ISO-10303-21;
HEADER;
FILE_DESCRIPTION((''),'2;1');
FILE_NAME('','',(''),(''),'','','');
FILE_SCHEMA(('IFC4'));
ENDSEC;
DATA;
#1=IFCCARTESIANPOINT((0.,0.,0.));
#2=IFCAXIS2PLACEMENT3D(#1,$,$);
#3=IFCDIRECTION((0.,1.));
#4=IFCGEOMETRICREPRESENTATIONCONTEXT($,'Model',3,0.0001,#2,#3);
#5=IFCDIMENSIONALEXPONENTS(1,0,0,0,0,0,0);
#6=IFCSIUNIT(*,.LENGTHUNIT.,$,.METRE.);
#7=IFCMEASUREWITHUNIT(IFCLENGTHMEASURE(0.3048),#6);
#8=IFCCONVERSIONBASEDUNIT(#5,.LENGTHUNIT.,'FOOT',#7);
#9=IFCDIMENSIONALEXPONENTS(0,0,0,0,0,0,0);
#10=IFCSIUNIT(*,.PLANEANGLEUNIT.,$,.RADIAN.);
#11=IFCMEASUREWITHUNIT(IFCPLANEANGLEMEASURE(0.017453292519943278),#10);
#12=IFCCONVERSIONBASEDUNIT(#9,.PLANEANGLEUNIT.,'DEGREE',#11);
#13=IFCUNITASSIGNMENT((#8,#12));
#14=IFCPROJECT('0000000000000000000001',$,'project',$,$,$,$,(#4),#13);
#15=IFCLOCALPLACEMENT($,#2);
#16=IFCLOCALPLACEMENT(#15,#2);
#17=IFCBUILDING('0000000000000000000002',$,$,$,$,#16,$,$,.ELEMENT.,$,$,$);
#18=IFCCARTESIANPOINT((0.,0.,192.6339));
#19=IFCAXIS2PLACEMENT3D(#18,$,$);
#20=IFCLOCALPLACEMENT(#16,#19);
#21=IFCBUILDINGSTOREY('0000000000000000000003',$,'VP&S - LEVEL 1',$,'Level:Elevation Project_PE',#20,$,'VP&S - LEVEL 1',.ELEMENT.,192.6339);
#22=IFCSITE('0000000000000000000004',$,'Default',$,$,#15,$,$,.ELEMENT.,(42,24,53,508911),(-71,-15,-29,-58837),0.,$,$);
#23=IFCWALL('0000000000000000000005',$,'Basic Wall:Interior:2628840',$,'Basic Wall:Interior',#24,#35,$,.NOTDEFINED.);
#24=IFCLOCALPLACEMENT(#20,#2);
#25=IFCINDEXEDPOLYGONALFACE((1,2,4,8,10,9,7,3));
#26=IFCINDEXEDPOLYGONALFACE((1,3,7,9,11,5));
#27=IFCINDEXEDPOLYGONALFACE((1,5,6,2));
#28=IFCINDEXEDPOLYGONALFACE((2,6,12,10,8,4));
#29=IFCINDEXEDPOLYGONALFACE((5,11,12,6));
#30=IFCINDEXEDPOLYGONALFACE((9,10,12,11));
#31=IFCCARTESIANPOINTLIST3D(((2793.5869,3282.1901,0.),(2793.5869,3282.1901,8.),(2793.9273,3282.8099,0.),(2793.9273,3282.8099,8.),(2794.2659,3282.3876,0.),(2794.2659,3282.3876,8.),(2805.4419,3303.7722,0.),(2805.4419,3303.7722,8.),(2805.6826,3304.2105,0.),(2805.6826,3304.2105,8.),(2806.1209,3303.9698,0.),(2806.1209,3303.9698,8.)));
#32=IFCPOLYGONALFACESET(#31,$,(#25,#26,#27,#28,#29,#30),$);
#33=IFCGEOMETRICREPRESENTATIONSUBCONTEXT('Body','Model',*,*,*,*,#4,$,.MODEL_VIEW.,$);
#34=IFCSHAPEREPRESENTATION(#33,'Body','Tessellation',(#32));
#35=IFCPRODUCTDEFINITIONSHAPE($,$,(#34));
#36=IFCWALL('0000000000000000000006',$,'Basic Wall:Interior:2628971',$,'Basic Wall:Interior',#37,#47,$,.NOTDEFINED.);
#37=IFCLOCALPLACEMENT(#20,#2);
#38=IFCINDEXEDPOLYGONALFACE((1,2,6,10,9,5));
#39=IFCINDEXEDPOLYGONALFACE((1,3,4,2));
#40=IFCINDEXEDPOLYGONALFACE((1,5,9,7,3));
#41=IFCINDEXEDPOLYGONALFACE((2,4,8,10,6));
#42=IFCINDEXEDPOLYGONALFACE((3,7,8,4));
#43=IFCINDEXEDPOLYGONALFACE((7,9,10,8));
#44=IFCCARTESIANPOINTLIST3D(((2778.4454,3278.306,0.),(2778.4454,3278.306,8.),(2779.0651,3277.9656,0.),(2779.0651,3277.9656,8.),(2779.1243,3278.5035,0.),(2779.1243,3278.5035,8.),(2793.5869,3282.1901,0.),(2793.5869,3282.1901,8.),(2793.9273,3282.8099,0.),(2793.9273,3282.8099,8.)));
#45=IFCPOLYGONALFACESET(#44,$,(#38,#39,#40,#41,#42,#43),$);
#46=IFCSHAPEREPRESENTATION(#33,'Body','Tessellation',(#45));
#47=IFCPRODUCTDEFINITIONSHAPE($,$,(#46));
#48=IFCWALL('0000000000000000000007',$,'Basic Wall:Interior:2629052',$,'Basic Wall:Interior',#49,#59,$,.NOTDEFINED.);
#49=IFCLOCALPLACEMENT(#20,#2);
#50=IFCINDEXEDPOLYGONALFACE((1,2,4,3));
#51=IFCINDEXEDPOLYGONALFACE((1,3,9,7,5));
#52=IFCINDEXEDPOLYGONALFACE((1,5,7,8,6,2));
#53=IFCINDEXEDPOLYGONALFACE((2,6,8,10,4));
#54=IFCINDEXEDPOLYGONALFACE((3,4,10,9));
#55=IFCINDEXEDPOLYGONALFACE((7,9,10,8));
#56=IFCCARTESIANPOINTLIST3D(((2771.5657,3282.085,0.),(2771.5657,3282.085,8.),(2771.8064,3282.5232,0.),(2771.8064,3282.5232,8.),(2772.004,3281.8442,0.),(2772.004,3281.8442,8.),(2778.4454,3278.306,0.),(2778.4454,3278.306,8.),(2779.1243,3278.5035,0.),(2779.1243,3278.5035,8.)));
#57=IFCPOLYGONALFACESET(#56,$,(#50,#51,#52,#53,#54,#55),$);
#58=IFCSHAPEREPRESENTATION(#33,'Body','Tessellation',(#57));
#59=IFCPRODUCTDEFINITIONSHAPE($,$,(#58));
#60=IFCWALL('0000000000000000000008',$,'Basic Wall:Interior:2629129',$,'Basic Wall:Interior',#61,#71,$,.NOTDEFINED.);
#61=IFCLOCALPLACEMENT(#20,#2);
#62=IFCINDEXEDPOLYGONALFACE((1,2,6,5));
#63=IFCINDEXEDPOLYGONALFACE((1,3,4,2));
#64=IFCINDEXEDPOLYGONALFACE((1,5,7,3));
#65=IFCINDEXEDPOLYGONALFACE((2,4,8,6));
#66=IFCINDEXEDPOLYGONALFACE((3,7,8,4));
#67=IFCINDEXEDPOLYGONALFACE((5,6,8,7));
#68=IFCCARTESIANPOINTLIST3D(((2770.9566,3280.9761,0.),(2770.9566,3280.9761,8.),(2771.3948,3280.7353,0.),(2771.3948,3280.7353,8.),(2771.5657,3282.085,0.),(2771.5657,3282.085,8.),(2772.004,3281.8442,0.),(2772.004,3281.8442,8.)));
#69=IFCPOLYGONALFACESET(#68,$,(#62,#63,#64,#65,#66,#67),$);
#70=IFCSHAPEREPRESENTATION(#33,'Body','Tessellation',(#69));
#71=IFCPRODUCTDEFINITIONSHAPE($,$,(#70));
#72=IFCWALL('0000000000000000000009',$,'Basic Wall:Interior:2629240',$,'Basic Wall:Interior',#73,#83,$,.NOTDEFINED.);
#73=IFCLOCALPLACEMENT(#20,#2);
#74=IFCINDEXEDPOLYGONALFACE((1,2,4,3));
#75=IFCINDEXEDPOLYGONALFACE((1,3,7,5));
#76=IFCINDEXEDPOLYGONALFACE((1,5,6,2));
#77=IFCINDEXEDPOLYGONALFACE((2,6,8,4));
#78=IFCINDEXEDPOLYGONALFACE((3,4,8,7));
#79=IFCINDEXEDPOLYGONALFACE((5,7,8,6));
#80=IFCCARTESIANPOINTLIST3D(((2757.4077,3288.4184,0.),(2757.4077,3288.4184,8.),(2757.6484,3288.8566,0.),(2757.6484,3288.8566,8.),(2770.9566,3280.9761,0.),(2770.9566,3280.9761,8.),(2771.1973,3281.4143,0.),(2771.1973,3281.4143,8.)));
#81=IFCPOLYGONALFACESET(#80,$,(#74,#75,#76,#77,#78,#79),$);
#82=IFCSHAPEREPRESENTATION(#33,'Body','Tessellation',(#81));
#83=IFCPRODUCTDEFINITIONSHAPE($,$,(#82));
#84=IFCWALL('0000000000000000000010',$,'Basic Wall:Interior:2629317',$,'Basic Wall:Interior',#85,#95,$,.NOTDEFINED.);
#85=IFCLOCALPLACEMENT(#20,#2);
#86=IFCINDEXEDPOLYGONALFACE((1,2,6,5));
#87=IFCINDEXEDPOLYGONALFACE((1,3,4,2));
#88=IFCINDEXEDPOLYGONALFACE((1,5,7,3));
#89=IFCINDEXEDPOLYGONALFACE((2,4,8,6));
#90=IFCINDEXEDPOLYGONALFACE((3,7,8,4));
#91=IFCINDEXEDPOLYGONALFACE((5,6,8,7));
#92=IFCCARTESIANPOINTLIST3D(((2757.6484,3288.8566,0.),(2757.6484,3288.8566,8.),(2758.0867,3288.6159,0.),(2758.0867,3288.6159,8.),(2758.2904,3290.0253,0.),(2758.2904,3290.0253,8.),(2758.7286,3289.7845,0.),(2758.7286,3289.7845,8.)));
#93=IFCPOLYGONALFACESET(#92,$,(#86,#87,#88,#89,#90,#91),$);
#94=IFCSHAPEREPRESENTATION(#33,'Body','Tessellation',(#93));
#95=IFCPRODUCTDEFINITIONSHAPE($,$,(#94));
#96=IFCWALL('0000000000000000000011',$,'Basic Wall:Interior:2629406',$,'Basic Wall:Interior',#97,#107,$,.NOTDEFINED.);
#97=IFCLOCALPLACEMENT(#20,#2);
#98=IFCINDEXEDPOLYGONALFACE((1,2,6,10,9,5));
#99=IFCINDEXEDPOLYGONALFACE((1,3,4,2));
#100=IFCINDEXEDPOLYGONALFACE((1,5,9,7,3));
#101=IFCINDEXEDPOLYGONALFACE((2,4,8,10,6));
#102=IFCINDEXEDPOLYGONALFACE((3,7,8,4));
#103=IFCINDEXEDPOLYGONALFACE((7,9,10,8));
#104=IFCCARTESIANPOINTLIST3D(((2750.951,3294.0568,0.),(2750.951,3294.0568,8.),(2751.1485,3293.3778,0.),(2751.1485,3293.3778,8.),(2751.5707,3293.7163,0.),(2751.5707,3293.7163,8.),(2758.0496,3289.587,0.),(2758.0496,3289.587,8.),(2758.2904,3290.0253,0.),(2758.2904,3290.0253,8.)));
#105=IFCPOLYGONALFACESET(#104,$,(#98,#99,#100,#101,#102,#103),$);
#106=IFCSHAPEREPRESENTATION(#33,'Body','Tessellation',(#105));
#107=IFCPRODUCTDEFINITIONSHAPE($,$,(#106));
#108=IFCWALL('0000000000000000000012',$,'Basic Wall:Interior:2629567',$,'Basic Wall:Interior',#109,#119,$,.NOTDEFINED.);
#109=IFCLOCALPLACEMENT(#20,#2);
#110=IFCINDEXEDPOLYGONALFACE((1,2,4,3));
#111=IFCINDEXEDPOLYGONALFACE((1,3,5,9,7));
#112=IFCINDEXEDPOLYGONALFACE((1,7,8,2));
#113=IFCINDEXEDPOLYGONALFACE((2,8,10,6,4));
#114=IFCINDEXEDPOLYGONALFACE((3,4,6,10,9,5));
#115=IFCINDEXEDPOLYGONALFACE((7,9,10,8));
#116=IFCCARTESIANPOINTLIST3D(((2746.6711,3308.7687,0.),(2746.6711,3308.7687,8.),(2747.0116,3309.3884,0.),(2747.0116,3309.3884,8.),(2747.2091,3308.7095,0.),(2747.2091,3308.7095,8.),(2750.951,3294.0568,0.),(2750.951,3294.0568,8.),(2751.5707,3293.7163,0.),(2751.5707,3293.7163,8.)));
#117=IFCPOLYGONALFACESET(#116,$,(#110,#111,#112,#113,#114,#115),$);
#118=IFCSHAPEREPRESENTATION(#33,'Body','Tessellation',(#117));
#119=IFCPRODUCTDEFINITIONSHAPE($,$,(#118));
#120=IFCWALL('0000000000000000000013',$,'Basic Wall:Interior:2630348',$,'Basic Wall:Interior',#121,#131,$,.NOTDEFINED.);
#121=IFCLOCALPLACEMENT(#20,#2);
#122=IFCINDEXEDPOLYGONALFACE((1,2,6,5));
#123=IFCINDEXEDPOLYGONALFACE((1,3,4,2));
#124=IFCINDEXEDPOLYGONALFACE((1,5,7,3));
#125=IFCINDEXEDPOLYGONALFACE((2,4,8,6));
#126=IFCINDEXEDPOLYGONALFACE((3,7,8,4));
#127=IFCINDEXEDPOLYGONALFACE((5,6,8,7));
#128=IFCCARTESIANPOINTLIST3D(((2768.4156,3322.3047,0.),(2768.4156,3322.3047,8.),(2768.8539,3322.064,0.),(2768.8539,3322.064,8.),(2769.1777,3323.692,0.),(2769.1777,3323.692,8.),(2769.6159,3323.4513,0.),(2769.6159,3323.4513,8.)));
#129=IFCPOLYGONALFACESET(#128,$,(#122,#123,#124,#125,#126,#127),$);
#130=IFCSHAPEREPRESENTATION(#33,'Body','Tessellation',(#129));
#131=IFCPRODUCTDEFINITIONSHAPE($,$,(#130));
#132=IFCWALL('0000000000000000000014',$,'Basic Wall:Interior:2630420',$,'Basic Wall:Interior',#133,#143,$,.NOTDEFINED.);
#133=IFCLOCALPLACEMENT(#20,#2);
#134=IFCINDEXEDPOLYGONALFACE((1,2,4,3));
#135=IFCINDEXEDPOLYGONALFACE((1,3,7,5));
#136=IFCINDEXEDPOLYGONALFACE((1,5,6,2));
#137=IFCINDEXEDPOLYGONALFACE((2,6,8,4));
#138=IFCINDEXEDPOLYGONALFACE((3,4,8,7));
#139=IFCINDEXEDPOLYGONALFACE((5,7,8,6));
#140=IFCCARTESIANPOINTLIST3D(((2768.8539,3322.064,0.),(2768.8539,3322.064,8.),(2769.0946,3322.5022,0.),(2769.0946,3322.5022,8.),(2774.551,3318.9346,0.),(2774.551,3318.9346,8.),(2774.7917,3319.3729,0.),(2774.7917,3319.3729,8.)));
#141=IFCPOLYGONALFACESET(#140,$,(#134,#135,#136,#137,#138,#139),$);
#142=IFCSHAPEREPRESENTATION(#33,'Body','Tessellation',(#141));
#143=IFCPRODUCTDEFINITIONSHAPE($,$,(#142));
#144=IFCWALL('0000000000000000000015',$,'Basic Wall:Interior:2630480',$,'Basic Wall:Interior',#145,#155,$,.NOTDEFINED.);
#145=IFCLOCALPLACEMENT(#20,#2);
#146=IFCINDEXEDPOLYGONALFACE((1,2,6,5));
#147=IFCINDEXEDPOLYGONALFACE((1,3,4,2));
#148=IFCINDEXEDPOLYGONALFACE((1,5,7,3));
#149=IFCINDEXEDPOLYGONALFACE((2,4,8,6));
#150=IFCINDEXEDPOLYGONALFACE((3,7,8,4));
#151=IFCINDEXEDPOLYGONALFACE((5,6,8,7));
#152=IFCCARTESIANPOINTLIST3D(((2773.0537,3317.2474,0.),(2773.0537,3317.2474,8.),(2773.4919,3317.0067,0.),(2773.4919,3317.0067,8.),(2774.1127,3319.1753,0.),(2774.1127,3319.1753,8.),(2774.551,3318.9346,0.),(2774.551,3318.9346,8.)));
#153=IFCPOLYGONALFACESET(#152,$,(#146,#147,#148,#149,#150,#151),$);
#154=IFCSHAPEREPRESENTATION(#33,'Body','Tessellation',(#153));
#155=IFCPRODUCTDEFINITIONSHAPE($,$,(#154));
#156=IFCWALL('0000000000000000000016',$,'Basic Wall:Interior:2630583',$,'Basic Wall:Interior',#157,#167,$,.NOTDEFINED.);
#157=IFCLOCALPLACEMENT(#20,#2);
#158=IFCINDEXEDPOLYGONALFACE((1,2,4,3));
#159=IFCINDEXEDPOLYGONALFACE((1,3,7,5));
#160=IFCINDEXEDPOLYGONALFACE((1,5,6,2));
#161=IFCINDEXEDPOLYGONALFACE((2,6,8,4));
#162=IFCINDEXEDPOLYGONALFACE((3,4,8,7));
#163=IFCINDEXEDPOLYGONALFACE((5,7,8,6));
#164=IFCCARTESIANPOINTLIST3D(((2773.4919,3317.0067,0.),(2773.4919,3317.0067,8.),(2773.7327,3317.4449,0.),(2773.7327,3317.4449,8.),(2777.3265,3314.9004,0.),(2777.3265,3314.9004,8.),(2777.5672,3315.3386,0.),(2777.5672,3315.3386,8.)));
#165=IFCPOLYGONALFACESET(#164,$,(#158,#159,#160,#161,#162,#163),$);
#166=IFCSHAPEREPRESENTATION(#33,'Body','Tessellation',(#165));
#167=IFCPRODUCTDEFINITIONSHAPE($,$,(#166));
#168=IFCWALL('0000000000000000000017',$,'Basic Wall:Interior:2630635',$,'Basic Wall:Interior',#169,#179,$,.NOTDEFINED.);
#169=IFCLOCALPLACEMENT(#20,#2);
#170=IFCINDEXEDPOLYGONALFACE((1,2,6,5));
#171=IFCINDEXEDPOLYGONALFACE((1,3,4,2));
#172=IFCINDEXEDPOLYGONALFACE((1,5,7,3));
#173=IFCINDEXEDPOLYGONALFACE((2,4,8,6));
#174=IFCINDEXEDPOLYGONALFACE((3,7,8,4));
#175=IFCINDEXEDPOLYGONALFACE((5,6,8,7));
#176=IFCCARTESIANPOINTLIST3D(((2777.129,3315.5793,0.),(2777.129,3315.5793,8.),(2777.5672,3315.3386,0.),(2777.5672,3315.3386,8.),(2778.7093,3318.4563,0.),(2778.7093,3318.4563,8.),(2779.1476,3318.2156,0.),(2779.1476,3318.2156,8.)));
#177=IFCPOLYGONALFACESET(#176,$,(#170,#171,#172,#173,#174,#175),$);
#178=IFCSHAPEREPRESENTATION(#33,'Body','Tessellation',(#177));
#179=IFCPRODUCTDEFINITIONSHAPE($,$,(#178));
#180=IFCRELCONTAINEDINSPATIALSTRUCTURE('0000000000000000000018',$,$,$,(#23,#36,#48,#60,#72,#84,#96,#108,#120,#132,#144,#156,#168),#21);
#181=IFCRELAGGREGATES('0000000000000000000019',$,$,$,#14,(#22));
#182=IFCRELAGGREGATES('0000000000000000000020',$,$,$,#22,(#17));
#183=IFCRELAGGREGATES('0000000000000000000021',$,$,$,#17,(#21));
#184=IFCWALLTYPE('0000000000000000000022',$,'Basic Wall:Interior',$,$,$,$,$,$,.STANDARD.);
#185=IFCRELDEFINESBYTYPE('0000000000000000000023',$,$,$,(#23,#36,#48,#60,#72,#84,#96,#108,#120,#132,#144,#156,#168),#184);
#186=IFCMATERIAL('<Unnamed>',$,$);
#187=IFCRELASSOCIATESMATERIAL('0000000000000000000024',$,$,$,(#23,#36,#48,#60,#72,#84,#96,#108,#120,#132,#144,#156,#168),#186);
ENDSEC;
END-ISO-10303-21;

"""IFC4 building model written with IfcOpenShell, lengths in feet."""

from ifc_helpers import new_model, entity, si_unit, converted_unit, direction, frame, origin, place, context, subcontext, project, spatial, indexed_curve, outline, extrude, material, type_object, element, save


model = new_model("IFC4")

# Units and contexts
model_context = context("Model", 3, precision=0.0001, world=origin(), true_north=direction((0.0, 1.0)))
body_context = subcontext(model_context, "Body", "Model", "MODEL_VIEW")
ifc_project = project(units=[converted_unit("LENGTHUNIT", "FOOT", entity("IfcLengthMeasure", 0.3048), si_unit("LENGTHUNIT", "METRE"), dimensions=[1, 0, 0, 0, 0, 0, 0]), converted_unit("PLANEANGLEUNIT", "DEGREE", entity("IfcPlaneAngleMeasure", 0.017453292519943278), si_unit("PLANEANGLEUNIT", "RADIAN"), dimensions=[0, 0, 0, 0, 0, 0, 0])], contexts=[model_context])

# Site, building, storey
site_placement = place(None, origin())
site = spatial("IfcSite", under=ifc_project, at=site_placement, Name="Default", CompositionType="ELEMENT", RefLatitude=(42, 24, 53, 508911), RefLongitude=(-71, -15, -29, -58837), RefElevation=0.0)
building_placement = place(site_placement, origin())
building = spatial("IfcBuilding", under=site, at=building_placement, CompositionType="ELEMENT")
storey_placement = place(building_placement, frame((0.0, 0.0, 192.6339)))
storey = spatial("IfcBuildingStorey", under=building, at=storey_placement, Name="VP&S - LEVEL 1", ObjectType="Level:Elevation Project_PE", LongName="VP&S - LEVEL 1", CompositionType="ELEMENT", Elevation=192.6339)

# Walls
ifc_material = material(Name="<Unnamed>")
wall_type = type_object("IfcWallType", Name="Basic Wall:Interior", PredefinedType="STANDARD")
wall_1_placement = place(storey_placement, frame((2805.9017, 3304.0901, 0.0), z_axis=(0.0, 0.0, 1.0), x_axis=(-0.481445, -0.876477, 0.0)))
element("IfcWall", 1, at=wall_1_placement, inside=storey, type_object=wall_type, material=ifc_material, Name="Basic Wall:Interior:2628840", ObjectType="Basic Wall:Interior", PredefinedType="NOTDEFINED", context=body_context, shape_type="SweptSolid", body=[
    extrude(outline(indexed_curve([(25.1238, -0.25), (24.6238, 0.25), (0.0, 0.25), (0.0, -0.25), (0.5, -0.25), (24.4167, -0.25), (25.1238, -0.25)], self_intersect=False)), origin(), (0.0, 0.0, 1.0), 8.0),
])
wall_2_placement = place(storey_placement, frame((2793.9972, 3282.5698, 0.0), z_axis=(0.0, 0.0, 1.0), x_axis=(-0.960195, -0.27933, 0.0)))
element("IfcWall", 2, at=wall_2_placement, inside=storey, type_object=wall_type, material=ifc_material, Name="Basic Wall:Interior:2628971", ObjectType="Basic Wall:Interior", PredefinedType="NOTDEFINED", context=body_context, shape_type="SweptSolid", body=[
    extrude(outline(indexed_curve([(16.1238, -0.25), (15.6238, 0.25), (0.5, 0.25), (0.0, -0.25), (15.4167, -0.25), (16.1238, -0.25)], self_intersect=False)), origin(), (0.0, 0.0, 1.0), 8.0),
])
wall_3_placement = place(storey_placement, frame((2779.004, 3278.2844, 0.0), z_axis=(0.0, 0.0, 1.0), x_axis=(-0.876477, 0.481445, 0.0)))
element("IfcWall", 3, at=wall_3_placement, inside=storey, type_object=wall_type, material=ifc_material, Name="Basic Wall:Interior:2629052", ObjectType="Basic Wall:Interior", PredefinedType="NOTDEFINED", context=body_context, shape_type="SweptSolid", body=[
    extrude(outline(indexed_curve([(8.3492, -0.25), (8.3492, 0.25), (7.8492, 0.25), (0.5, 0.25), (0.0, -0.25), (8.3492, -0.25)], self_intersect=False)), origin(), (0.0, 0.0, 1.0), 8.0),
])
wall_4_placement = place(storey_placement, frame((2771.7848, 3281.9646, 0.0), z_axis=(0.0, 0.0, 1.0), x_axis=(-0.481445, -0.876477, 0.0)))
element("IfcWall", 4, at=wall_4_placement, inside=storey, type_object=wall_type, material=ifc_material, Name="Basic Wall:Interior:2629129", ObjectType="Basic Wall:Interior", PredefinedType="NOTDEFINED", context=body_context, shape_type="SweptSolid", body=[
    extrude(outline(indexed_curve([(1.2652, 0.25), (0.0, 0.25), (0.0, -0.25), (1.2652, -0.25), (1.2652, 0.25)], self_intersect=False)), origin(), (0.0, 0.0, 1.0), 8.0),
])
wall_5_placement = place(storey_placement, frame((2771.077, 3281.1952, 0.0), z_axis=(0.0, 0.0, 1.0), x_axis=(-0.876477, 0.481445, 0.0)))
element("IfcWall", 5, at=wall_5_placement, inside=storey, type_object=wall_type, material=ifc_material, Name="Basic Wall:Interior:2629240", ObjectType="Basic Wall:Interior", PredefinedType="NOTDEFINED", context=body_context, shape_type="SweptSolid", body=[
    extrude(outline(indexed_curve([(15.4583, 0.25), (0.0, 0.25), (0.0, -0.25), (15.4583, -0.25), (15.4583, 0.25)], self_intersect=False)), origin(), (0.0, 0.0, 1.0), 8.0),
])
wall_6_placement = place(storey_placement, frame((2757.8676, 3288.7363, 0.0), z_axis=(0.0, 0.0, 1.0), x_axis=(0.481445, 0.876477, 0.0)))
element("IfcWall", 6, at=wall_6_placement, inside=storey, type_object=wall_type, material=ifc_material, Name="Basic Wall:Interior:2629317", ObjectType="Basic Wall:Interior", PredefinedType="NOTDEFINED", context=body_context, shape_type="SweptSolid", body=[
    extrude(outline(indexed_curve([(1.3333, 0.25), (0.0, 0.25), (0.0, -0.25), (1.3333, -0.25), (1.3333, 0.25)], self_intersect=False)), origin(), (0.0, 0.0, 1.0), 8.0),
])
wall_7_placement = place(storey_placement, frame((2758.17, 3289.8061, 0.0), z_axis=(0.0, 0.0, 1.0), x_axis=(-0.876477, 0.481445, 0.0)))
element("IfcWall", 7, at=wall_7_placement, inside=storey, type_object=wall_type, material=ifc_material, Name="Basic Wall:Interior:2629406", ObjectType="Basic Wall:Interior", PredefinedType="NOTDEFINED", context=body_context, shape_type="SweptSolid", body=[
    extrude(outline(indexed_curve([(8.3738, -0.25), (7.8738, 0.25), (0.0, 0.25), (0.0, -0.25), (7.6667, -0.25), (8.3738, -0.25)], self_intersect=False)), origin(), (0.0, 0.0, 1.0), 8.0),
])
wall_8_placement = place(storey_placement, frame((2751.3307, 3293.6465, 0.0), z_axis=(0.0, 0.0, 1.0), x_axis=(-0.27933, 0.960195, 0.0)))
element("IfcWall", 8, at=wall_8_placement, inside=storey, type_object=wall_type, material=ifc_material, Name="Basic Wall:Interior:2629567", ObjectType="Basic Wall:Interior", PredefinedType="NOTDEFINED", context=body_context, shape_type="SweptSolid", body=[
    extrude(outline(indexed_curve([(16.3218, -0.25), (15.8218, 0.25), (0.5, 0.25), (0.0, -0.25), (15.6146, -0.25), (16.3218, -0.25)], self_intersect=False)), origin(), (0.0, 0.0, 1.0), 8.0),
])
wall_9_placement = place(storey_placement, frame((2769.3968, 3323.5717, 0.0), z_axis=(0.0, 0.0, 1.0), x_axis=(-0.481445, -0.876477, 0.0)))
element("IfcWall", 9, at=wall_9_placement, inside=storey, type_object=wall_type, material=ifc_material, Name="Basic Wall:Interior:2630348", ObjectType="Basic Wall:Interior", PredefinedType="NOTDEFINED", context=body_context, shape_type="SweptSolid", body=[
    extrude(outline(indexed_curve([(1.5828, 0.25), (0.0, 0.25), (0.0, -0.25), (1.5828, -0.25), (1.5828, 0.25)], self_intersect=False)), origin(), (0.0, 0.0, 1.0), 8.0),
])
wall_10_placement = place(storey_placement, frame((2768.9742, 3322.2831, 0.0), z_axis=(0.0, 0.0, 1.0), x_axis=(0.876477, -0.481445, 0.0)))
element("IfcWall", 10, at=wall_10_placement, inside=storey, type_object=wall_type, material=ifc_material, Name="Basic Wall:Interior:2630420", ObjectType="Basic Wall:Interior", PredefinedType="NOTDEFINED", context=body_context, shape_type="SweptSolid", body=[
    extrude(outline(indexed_curve([(6.5, 0.25), (0.0, 0.25), (0.0, -0.25), (6.5, -0.25), (6.5, 0.25)], self_intersect=False)), origin(), (0.0, 0.0, 1.0), 8.0),
])
wall_11_placement = place(storey_placement, frame((2774.3318, 3319.055, 0.0), z_axis=(0.0, 0.0, 1.0), x_axis=(-0.481445, -0.876477, 0.0)))
element("IfcWall", 11, at=wall_11_placement, inside=storey, type_object=wall_type, material=ifc_material, Name="Basic Wall:Interior:2630480", ObjectType="Basic Wall:Interior", PredefinedType="NOTDEFINED", context=body_context, shape_type="SweptSolid", body=[
    extrude(outline(indexed_curve([(2.1997, 0.25), (0.0, 0.25), (0.0, -0.25), (2.1997, -0.25), (2.1997, 0.25)], self_intersect=False)), origin(), (0.0, 0.0, 1.0), 8.0),
])
wall_12_placement = place(storey_placement, frame((2773.6123, 3317.2258, 0.0), z_axis=(0.0, 0.0, 1.0), x_axis=(0.876477, -0.481445, 0.0)))
element("IfcWall", 12, at=wall_12_placement, inside=storey, type_object=wall_type, material=ifc_material, Name="Basic Wall:Interior:2630583", ObjectType="Basic Wall:Interior", PredefinedType="NOTDEFINED", context=body_context, shape_type="SweptSolid", body=[
    extrude(outline(indexed_curve([(4.375, 0.25), (0.0, 0.25), (0.0, -0.25), (4.375, -0.25), (4.375, 0.25)], self_intersect=False)), origin(), (0.0, 0.0, 1.0), 8.0),
])
wall_13_placement = place(storey_placement, frame((2777.3481, 3315.459, 0.0), z_axis=(0.0, 0.0, 1.0), x_axis=(0.481445, 0.876477, 0.0)))
element("IfcWall", 13, at=wall_13_placement, inside=storey, type_object=wall_type, material=ifc_material, Name="Basic Wall:Interior:2630635", ObjectType="Basic Wall:Interior", PredefinedType="NOTDEFINED", context=body_context, shape_type="SweptSolid", body=[
    extrude(outline(indexed_curve([(3.2825, 0.25), (0.0, 0.25), (0.0, -0.25), (3.2825, -0.25), (3.2825, 0.25)], self_intersect=False)), origin(), (0.0, 0.0, 1.0), 8.0),
])

save(model, "model.ifc")
